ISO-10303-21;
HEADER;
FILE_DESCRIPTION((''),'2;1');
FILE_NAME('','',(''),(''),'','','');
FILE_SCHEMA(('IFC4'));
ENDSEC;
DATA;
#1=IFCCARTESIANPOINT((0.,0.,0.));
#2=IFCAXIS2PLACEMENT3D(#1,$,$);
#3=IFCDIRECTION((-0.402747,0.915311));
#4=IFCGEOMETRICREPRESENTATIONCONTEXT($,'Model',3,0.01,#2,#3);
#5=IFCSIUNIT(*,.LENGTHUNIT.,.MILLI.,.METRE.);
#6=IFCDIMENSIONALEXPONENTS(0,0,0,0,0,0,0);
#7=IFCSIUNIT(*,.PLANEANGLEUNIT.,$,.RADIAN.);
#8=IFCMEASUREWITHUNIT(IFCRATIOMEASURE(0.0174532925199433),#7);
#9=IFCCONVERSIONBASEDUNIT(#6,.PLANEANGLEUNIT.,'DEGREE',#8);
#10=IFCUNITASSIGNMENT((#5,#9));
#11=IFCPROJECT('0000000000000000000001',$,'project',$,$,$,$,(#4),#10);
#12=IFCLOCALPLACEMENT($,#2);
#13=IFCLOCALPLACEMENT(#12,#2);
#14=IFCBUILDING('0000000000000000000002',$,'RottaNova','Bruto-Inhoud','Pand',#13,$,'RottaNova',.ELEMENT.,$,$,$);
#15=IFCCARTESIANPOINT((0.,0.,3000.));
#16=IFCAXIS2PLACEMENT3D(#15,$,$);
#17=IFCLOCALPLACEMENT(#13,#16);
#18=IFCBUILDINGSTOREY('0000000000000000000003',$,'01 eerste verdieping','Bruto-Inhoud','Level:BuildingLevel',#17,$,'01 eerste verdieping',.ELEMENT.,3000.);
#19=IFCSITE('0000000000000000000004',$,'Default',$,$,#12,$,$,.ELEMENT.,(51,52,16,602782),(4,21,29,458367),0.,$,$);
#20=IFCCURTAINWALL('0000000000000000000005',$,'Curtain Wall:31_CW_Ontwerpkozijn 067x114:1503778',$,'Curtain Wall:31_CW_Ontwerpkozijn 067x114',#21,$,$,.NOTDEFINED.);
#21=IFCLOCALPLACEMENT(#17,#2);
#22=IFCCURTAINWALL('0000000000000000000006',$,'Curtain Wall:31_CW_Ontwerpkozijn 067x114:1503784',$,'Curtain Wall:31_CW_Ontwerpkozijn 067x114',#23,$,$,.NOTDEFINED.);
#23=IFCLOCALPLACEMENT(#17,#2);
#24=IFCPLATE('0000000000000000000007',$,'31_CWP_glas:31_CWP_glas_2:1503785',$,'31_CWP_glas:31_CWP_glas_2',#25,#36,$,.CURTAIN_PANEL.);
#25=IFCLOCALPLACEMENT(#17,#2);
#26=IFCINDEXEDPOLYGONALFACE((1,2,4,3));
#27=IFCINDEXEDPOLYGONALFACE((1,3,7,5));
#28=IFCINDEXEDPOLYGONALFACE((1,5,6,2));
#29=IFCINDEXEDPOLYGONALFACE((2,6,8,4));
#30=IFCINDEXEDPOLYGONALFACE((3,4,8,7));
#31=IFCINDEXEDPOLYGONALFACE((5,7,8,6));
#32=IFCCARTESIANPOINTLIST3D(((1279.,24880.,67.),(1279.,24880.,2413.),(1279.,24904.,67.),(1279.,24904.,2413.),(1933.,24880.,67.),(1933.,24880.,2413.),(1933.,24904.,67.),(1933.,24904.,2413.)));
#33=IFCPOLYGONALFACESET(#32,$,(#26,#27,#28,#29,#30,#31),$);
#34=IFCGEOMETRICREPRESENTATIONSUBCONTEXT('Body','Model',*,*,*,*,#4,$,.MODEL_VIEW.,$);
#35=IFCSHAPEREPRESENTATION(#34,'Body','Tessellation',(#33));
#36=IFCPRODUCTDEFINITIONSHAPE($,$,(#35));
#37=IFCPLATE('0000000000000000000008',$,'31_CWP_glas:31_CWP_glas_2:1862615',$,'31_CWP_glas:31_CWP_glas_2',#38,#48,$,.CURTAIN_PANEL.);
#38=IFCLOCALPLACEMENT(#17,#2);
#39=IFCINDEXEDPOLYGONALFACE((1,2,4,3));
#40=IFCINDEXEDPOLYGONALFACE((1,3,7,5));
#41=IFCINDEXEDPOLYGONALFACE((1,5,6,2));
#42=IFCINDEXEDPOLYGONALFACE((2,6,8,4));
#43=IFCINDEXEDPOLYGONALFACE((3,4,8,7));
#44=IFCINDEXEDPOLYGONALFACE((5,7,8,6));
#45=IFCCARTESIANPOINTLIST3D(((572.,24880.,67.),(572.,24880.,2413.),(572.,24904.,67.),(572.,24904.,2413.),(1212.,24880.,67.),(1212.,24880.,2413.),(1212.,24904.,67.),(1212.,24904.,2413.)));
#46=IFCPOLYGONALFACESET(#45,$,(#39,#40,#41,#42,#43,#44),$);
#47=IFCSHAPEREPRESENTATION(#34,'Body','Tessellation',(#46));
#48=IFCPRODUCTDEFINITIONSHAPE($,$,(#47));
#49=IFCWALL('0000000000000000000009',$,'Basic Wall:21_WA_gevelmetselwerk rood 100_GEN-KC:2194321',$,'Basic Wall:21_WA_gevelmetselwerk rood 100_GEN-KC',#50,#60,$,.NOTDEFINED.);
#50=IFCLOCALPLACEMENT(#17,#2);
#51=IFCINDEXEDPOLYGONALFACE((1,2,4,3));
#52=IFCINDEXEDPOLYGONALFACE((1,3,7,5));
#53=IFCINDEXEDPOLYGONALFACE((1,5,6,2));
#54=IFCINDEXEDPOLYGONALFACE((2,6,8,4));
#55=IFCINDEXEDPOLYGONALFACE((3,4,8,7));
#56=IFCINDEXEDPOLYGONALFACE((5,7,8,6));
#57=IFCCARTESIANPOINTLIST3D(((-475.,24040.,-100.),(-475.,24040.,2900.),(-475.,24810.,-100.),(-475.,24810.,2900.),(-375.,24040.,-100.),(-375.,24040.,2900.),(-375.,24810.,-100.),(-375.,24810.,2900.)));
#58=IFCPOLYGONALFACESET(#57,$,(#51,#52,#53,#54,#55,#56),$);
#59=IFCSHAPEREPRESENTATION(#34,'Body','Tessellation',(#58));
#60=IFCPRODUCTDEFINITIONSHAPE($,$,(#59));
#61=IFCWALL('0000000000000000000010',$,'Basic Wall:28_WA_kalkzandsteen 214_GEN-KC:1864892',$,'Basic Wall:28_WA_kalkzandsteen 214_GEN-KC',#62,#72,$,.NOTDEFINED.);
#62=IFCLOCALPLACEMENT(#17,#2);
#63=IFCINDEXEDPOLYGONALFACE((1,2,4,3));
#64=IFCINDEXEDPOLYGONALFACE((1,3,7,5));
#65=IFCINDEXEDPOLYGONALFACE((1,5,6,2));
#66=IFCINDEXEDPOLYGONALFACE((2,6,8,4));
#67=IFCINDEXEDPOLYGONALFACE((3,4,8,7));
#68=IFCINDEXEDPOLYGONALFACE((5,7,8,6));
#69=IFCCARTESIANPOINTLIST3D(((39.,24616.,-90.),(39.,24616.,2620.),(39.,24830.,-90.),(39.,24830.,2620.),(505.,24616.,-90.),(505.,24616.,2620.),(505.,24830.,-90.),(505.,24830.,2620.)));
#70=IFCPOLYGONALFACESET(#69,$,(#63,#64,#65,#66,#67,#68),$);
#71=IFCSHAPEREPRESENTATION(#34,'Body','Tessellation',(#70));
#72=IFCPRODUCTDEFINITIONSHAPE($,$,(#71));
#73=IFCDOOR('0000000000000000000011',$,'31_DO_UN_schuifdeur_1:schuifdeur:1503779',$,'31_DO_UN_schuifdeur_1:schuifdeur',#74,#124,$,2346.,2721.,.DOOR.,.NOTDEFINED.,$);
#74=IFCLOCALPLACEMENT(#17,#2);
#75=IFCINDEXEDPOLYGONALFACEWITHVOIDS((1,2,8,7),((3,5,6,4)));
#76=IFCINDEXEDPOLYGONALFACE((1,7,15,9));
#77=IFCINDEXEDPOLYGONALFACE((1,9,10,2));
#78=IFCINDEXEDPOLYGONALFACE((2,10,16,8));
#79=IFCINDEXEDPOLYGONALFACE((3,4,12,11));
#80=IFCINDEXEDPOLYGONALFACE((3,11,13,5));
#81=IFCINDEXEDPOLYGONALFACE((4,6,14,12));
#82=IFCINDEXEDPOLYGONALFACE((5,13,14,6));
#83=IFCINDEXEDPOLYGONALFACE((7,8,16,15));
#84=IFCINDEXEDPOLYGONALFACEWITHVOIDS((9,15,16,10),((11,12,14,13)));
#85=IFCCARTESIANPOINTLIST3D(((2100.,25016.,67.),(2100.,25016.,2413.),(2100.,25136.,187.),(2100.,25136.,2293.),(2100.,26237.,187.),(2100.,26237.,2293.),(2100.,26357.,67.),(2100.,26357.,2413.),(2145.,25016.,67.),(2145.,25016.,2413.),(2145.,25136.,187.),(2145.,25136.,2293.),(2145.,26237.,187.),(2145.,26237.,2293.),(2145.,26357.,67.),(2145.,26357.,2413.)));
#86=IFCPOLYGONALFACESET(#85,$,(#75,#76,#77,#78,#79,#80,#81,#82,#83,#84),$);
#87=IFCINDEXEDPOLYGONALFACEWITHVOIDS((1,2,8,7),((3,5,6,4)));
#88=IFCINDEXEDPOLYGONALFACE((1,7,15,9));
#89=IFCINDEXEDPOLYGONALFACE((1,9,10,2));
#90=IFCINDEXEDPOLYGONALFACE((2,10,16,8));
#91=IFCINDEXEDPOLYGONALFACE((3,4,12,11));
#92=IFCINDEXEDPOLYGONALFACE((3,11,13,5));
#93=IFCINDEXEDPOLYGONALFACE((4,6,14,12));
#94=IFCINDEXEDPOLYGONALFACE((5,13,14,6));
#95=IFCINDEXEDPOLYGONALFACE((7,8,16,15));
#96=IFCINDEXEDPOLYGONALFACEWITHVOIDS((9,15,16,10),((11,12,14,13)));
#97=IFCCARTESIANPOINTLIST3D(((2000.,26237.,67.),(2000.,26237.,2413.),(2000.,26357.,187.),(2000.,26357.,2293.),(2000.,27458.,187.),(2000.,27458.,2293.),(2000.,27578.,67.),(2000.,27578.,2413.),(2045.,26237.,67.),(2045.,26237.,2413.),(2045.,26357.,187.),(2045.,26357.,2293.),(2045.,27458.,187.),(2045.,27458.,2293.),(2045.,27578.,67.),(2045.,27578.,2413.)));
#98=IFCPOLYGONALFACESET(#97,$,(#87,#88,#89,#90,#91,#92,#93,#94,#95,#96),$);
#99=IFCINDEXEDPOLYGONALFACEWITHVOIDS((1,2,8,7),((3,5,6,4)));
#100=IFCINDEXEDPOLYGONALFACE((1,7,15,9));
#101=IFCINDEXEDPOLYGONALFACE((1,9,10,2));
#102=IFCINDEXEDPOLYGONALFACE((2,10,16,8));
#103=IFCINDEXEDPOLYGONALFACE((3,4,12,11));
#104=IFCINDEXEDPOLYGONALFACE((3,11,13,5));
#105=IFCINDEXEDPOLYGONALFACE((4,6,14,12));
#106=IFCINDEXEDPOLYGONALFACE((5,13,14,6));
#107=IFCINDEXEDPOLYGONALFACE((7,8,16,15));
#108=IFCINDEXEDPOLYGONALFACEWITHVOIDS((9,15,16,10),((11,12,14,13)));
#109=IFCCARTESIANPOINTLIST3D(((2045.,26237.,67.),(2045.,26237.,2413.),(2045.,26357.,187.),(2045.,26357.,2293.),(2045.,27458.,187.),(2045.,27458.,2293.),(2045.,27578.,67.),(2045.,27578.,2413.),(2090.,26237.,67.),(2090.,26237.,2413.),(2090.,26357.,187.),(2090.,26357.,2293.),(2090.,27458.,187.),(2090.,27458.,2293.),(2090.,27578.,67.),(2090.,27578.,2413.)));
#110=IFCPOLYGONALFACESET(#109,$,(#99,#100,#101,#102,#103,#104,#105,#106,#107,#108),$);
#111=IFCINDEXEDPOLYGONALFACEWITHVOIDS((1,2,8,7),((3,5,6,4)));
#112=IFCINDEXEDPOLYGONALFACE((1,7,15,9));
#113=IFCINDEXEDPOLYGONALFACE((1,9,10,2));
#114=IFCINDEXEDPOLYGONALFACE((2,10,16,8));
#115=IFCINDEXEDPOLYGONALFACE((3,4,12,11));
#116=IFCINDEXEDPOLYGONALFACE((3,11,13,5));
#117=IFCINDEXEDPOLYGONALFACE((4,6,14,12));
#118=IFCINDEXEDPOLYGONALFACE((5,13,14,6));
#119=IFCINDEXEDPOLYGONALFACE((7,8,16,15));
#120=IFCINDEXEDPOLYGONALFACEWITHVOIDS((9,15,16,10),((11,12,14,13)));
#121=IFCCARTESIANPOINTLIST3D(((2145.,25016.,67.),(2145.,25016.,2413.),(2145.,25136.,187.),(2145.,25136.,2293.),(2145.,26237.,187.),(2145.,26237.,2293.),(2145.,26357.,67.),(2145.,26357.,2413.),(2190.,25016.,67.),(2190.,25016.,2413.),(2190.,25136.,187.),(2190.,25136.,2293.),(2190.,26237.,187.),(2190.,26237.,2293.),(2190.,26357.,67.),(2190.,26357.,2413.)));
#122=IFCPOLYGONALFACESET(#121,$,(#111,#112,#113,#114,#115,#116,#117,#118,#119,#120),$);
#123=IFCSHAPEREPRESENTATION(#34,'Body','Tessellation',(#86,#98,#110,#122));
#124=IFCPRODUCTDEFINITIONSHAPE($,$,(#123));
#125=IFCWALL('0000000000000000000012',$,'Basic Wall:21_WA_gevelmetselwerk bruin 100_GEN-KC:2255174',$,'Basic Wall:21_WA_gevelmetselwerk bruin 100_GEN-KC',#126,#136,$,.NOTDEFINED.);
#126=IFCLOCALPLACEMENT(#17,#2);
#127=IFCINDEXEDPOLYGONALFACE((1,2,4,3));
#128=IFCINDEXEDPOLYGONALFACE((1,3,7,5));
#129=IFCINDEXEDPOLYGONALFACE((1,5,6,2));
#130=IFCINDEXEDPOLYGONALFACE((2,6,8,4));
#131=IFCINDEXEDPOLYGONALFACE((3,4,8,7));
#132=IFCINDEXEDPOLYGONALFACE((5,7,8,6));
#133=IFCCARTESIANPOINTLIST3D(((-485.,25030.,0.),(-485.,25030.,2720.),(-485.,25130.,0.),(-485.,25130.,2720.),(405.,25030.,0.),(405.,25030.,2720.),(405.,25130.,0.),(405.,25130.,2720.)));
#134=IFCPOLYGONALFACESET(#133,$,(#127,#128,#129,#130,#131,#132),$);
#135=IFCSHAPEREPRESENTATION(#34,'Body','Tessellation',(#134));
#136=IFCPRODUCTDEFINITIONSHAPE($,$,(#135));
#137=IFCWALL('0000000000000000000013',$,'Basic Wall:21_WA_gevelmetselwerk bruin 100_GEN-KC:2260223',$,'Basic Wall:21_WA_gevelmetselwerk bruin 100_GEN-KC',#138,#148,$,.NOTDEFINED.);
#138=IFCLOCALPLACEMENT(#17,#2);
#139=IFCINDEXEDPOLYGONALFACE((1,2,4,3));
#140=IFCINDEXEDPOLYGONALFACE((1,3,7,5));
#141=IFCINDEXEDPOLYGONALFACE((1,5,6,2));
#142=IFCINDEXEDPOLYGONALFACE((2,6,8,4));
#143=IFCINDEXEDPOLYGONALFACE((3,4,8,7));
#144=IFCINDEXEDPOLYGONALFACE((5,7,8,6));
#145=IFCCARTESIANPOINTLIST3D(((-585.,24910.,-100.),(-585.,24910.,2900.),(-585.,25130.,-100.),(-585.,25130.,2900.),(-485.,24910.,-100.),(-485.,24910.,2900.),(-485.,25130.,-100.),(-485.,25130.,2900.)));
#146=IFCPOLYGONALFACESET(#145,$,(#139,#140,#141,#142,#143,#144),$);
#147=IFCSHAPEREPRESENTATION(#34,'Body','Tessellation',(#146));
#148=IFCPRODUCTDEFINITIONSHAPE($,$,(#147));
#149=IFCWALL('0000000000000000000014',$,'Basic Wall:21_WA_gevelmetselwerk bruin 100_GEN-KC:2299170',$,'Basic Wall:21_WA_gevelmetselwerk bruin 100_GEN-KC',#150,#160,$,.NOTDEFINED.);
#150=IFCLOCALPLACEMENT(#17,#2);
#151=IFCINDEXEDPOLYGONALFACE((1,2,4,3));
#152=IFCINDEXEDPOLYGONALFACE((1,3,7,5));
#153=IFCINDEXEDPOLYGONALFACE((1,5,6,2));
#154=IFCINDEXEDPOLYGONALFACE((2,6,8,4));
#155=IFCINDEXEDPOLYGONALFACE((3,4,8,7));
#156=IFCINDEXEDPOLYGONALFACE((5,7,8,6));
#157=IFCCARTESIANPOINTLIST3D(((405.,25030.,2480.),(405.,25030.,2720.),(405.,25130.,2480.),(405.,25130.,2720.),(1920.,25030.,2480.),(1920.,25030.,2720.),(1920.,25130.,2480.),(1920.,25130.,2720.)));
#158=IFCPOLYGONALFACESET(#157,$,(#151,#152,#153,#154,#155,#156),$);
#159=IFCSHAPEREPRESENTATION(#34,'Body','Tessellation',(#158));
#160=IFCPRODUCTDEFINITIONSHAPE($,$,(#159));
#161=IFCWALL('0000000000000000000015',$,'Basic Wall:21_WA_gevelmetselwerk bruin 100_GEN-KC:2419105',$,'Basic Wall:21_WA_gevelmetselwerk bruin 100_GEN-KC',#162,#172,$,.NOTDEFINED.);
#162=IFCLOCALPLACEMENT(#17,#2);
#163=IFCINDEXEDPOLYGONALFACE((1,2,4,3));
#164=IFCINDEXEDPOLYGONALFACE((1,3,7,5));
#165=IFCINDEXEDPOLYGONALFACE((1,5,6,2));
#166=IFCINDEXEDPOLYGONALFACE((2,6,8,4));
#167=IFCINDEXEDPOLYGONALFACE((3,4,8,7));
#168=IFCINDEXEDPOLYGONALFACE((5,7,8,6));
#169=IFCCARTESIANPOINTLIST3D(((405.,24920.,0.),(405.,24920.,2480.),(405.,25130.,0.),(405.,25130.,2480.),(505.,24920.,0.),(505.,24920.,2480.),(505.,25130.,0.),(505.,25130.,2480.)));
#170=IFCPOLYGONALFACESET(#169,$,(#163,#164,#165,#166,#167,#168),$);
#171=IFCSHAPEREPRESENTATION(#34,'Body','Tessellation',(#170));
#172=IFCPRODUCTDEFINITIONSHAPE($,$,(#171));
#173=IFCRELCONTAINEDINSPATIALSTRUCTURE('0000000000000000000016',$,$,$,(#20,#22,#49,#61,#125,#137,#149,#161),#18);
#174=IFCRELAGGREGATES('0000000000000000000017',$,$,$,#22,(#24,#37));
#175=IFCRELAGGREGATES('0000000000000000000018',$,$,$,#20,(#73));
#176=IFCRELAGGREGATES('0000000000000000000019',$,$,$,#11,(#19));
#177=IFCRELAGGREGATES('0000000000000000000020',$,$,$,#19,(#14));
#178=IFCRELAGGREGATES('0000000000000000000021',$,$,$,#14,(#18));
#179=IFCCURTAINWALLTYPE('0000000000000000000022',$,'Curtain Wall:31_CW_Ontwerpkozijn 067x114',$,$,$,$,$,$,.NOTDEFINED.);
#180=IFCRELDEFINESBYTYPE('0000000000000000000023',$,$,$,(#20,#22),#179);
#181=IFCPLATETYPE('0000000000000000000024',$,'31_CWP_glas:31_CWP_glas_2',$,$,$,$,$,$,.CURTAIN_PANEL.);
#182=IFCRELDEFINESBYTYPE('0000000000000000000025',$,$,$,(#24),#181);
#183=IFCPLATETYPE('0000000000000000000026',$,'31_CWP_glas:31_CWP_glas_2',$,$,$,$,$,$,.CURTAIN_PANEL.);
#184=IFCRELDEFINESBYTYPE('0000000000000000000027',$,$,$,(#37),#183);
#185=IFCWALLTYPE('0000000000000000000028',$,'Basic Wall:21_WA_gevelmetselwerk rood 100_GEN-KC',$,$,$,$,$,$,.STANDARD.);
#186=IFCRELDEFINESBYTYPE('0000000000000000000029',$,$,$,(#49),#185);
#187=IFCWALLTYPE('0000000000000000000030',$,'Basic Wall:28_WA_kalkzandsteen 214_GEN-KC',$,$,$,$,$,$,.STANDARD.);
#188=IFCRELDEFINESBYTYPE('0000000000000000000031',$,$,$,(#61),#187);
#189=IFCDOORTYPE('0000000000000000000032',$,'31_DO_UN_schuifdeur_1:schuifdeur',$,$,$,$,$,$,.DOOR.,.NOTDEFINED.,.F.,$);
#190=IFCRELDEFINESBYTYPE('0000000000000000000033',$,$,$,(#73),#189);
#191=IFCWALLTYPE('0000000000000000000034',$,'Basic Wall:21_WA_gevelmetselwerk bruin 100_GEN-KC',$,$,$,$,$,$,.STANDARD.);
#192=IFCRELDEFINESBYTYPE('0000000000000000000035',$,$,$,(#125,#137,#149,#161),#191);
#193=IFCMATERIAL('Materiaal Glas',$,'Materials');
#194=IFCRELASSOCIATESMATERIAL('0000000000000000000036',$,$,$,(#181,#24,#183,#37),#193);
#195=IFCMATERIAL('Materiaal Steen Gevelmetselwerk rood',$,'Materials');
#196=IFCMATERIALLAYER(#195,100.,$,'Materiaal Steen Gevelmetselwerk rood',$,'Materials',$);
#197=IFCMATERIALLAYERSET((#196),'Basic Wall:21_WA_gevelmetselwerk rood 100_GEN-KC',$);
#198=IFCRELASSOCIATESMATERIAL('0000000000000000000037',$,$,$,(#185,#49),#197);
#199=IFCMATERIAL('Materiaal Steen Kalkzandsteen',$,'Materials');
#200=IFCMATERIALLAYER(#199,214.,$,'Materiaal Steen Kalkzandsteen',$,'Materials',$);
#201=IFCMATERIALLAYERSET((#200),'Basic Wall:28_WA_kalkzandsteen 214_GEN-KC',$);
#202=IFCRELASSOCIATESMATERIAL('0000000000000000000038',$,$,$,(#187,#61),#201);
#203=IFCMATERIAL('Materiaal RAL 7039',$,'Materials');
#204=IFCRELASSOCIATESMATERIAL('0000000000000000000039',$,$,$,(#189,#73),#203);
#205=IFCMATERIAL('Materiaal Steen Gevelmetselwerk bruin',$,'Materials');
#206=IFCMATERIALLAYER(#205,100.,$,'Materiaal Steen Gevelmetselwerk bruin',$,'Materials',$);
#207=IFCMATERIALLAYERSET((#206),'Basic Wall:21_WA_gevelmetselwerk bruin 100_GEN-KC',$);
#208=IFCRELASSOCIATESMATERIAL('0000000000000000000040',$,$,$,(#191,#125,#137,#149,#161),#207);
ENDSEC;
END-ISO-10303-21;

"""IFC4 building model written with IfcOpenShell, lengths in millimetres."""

from ifc_helpers import new_model, entity, si_unit, converted_unit, direction, frame, frame_2d, origin, place, context, subcontext, project, spatial, polyline, rectangle, outline, extrude, source, transform, mapped, material, layer, layer_set, type_object, type_shapes, element, aggregate, save


model = new_model("IFC4")

# Units and contexts
model_context = context("Model", 3, precision=0.01, world=origin(), true_north=direction((-0.402747, 0.915311)))
body_context = subcontext(model_context, "Body", "Model", "MODEL_VIEW")
ifc_project = project(units=[si_unit("LENGTHUNIT", "METRE", prefix="MILLI"), converted_unit("PLANEANGLEUNIT", "DEGREE", entity("IfcRatioMeasure", 0.0174532925199433), si_unit("PLANEANGLEUNIT", "RADIAN"), dimensions=[0, 0, 0, 0, 0, 0, 0])], contexts=[model_context])

# Site, building, storey
site_placement = place(None, origin())
site = spatial("IfcSite", under=ifc_project, at=site_placement, Name="Default", CompositionType="ELEMENT", RefLatitude=(51, 52, 16, 602782), RefLongitude=(4, 21, 29, 458367), RefElevation=0.0)
building_placement = place(site_placement, origin())
building = spatial("IfcBuilding", under=site, at=building_placement, Name="RottaNova", Description="Bruto-Inhoud", ObjectType="Pand", LongName="RottaNova", CompositionType="ELEMENT")
storey_placement = place(building_placement, frame((0.0, 0.0, 3000.0)))
storey = spatial("IfcBuildingStorey", under=building, at=storey_placement, Name="01 eerste verdieping", Description="Bruto-Inhoud", ObjectType="Level:BuildingLevel", LongName="01 eerste verdieping", CompositionType="ELEMENT", Elevation=3000.0)

# Curtain walls
curtain_wall_type = type_object("IfcCurtainWallType", Name="Curtain Wall:31_CW_Ontwerpkozijn 067x114", PredefinedType="NOTDEFINED")
curtain_wall_1_placement = place(storey_placement, frame((0.0, 0.0, -3000.0)))
curtain_wall_1 = element("IfcCurtainWall", 1, at=curtain_wall_1_placement, inside=storey, type_object=curtain_wall_type, Name="Curtain Wall:31_CW_Ontwerpkozijn 067x114:1503778", ObjectType="Curtain Wall:31_CW_Ontwerpkozijn 067x114", PredefinedType="NOTDEFINED")
ifc_material_1 = material(Name="Materiaal RAL 7039", Category="Materials")
curtain_wall_2_placement = place(storey_placement, frame((0.0, 0.0, -3000.0)))
curtain_wall_2 = element("IfcCurtainWall", 2, at=curtain_wall_2_placement, inside=storey, type_object=curtain_wall_type, Name="Curtain Wall:31_CW_Ontwerpkozijn 067x114:1503784", ObjectType="Curtain Wall:31_CW_Ontwerpkozijn 067x114", PredefinedType="NOTDEFINED")

# Plates
ifc_material_2 = material(Name="Materiaal Glas", Category="Materials")
plate_type_1 = type_object("IfcPlateType", Name="31_CWP_glas:31_CWP_glas_2", PredefinedType="CURTAIN_PANEL", material=ifc_material_2)
shared_shape_1 = source(origin(), body_context, "Body", "SweptSolid", [
    extrude(rectangle(XDim=24.0, YDim=654.0, at=frame_2d((0.0, 0.0), x_axis=(1.0, 0.0))), frame((327.0, 12.0, 0.0), z_axis=(0.0, 0.0, 1.0), x_axis=(0.0, 1.0, 0.0)), (0.0, 0.0, 1.0), 2346.0),
])
type_shapes(plate_type_1, [shared_shape_1])
plate_1_placement = place(curtain_wall_2_placement, frame((1933.0, 24904.0, 3067.0), z_axis=(0.0, 0.0, 1.0), x_axis=(-1.0, 0.0, 0.0)))
plate_1 = element("IfcPlate", 3, at=plate_1_placement, type_object=plate_type_1, material=ifc_material_2, Name="31_CWP_glas:31_CWP_glas_2:1503785", ObjectType="31_CWP_glas:31_CWP_glas_2", PredefinedType="CURTAIN_PANEL", context=body_context, shape_type="MappedRepresentation", body=[
    mapped(shared_shape_1, transform((0.0, 0.0, 0.0), scale=1.0)),
])
plate_type_2 = type_object("IfcPlateType", Name="31_CWP_glas:31_CWP_glas_2", PredefinedType="CURTAIN_PANEL", material=ifc_material_2)
shared_shape_2 = source(origin(), body_context, "Body", "SweptSolid", [
    extrude(rectangle(XDim=24.0, YDim=640.0, at=frame_2d((0.0, 0.0), x_axis=(1.0, 0.0))), frame((320.0, 12.0, 0.0), z_axis=(0.0, 0.0, 1.0), x_axis=(0.0, 1.0, 0.0)), (0.0, 0.0, 1.0), 2346.0),
])
type_shapes(plate_type_2, [shared_shape_2])
plate_2_placement = place(curtain_wall_2_placement, frame((1212.0, 24904.0, 3067.0), z_axis=(0.0, 0.0, 1.0), x_axis=(-1.0, 0.0, 0.0)))
plate_2 = element("IfcPlate", 4, at=plate_2_placement, type_object=plate_type_2, material=ifc_material_2, Name="31_CWP_glas:31_CWP_glas_2:1862615", ObjectType="31_CWP_glas:31_CWP_glas_2", PredefinedType="CURTAIN_PANEL", context=body_context, shape_type="MappedRepresentation", body=[
    mapped(shared_shape_2, transform((0.0, 0.0, 0.0), scale=1.0)),
])
aggregate(curtain_wall_2, [plate_1, plate_2])

# Walls
ifc_material_3 = material(Name="Materiaal Steen Gevelmetselwerk rood", Category="Materials")
ifc_layer_1 = layer(ifc_material_3, 100.0, Name="Materiaal Steen Gevelmetselwerk rood", Category="Materials")
ifc_layer_set_1 = layer_set([ifc_layer_1], Name="Basic Wall:21_WA_gevelmetselwerk rood 100_GEN-KC")
wall_type_1 = type_object("IfcWallType", Name="Basic Wall:21_WA_gevelmetselwerk rood 100_GEN-KC", PredefinedType="STANDARD", material=ifc_layer_set_1)
wall_1_placement = place(storey_placement, frame((-425.0, 24810.0, -100.0), z_axis=(0.0, 0.0, 1.0), x_axis=(0.0, -1.0, 0.0)))
element("IfcWall", 5, at=wall_1_placement, inside=storey, type_object=wall_type_1, material=ifc_layer_set_1, Name="Basic Wall:21_WA_gevelmetselwerk rood 100_GEN-KC:2194321", ObjectType="Basic Wall:21_WA_gevelmetselwerk rood 100_GEN-KC", PredefinedType="NOTDEFINED", context=body_context, shape_type="SweptSolid", body=[
    extrude(rectangle(XDim=770.0, YDim=100.0, at=frame_2d((385.0, 0.0), x_axis=(-1.0, 0.0))), origin(), (0.0, 0.0, 1.0), 3000.0),
])
ifc_material_4 = material(Name="Materiaal Steen Kalkzandsteen", Category="Materials")
ifc_layer_2 = layer(ifc_material_4, 214.0, Name="Materiaal Steen Kalkzandsteen", Category="Materials")
ifc_layer_set_2 = layer_set([ifc_layer_2], Name="Basic Wall:28_WA_kalkzandsteen 214_GEN-KC")
wall_type_2 = type_object("IfcWallType", Name="Basic Wall:28_WA_kalkzandsteen 214_GEN-KC", PredefinedType="STANDARD", material=ifc_layer_set_2)
wall_2_placement = place(storey_placement, frame((39.0, 24723.0, -90.0)))
element("IfcWall", 6, at=wall_2_placement, inside=storey, type_object=wall_type_2, material=ifc_layer_set_2, Name="Basic Wall:28_WA_kalkzandsteen 214_GEN-KC:1864892", ObjectType="Basic Wall:28_WA_kalkzandsteen 214_GEN-KC", PredefinedType="NOTDEFINED", context=body_context, shape_type="SweptSolid", body=[
    extrude(rectangle(XDim=466.0, YDim=214.0, at=frame_2d((233.0, 0.0), x_axis=(-1.0, 0.0))), origin(), (0.0, 0.0, 1.0), 2710.0),
])

# Door
door_type = type_object("IfcDoorType", Name="31_DO_UN_schuifdeur_1:schuifdeur", OperationType="NOTDEFINED", ParameterTakesPrecedence=False, PredefinedType="DOOR", material=ifc_material_1)
shared_shape_3 = source(origin(), body_context, "Body", "SweptSolid", [
    extrude(outline(polyline([(-670.5, -1173.0), (670.5, -1173.0), (670.5, 1173.0), (-670.5, 1173.0), (-670.5, -1173.0)]), holes=[polyline([(-550.5, -1053.0), (-550.5, 1053.0), (550.5, 1053.0), (550.5, -1053.0), (-550.5, -1053.0)])]), frame((-610.5, 90.0, 1173.0), z_axis=(0.0, -1.0, 0.0), x_axis=(-1.0, 0.0, 0.0)), (0.0, 0.0, 1.0), 45.0),
    extrude(outline(polyline([(-670.5, -1173.0), (670.5, -1173.0), (670.5, 1173.0), (-670.5, 1173.0), (-670.5, -1173.0)]), holes=[polyline([(-550.5, -1053.0), (-550.5, 1053.0), (550.5, 1053.0), (550.5, -1053.0), (-550.5, -1053.0)])]), frame((610.5, 190.0, 1173.0), z_axis=(0.0, -1.0, 0.0), x_axis=(-1.0, 0.0, 0.0)), (0.0, 0.0, 1.0), 45.0),
    extrude(outline(polyline([(-670.5, -1173.0), (670.5, -1173.0), (670.5, 1173.0), (-670.5, 1173.0), (-670.5, -1173.0)]), holes=[polyline([(-550.5, -1053.0), (-550.5, 1053.0), (550.5, 1053.0), (550.5, -1053.0), (-550.5, -1053.0)])]), frame((610.5, 145.0, 1173.0), z_axis=(0.0, -1.0, 0.0), x_axis=(-1.0, 0.0, 0.0)), (0.0, 0.0, 1.0), 45.0),
    extrude(outline(polyline([(-670.5, -1173.0), (670.5, -1173.0), (670.5, 1173.0), (-670.5, 1173.0), (-670.5, -1173.0)]), holes=[polyline([(-550.5, -1053.0), (-550.5, 1053.0), (550.5, 1053.0), (550.5, -1053.0), (-550.5, -1053.0)])]), frame((-610.5, 45.0, 1173.0), z_axis=(0.0, -1.0, 0.0), x_axis=(-1.0, 0.0, 0.0)), (0.0, 0.0, 1.0), 45.0),
])
type_shapes(door_type, [shared_shape_3])
door_placement = place(curtain_wall_1_placement, frame((2190.0, 26297.0, 3067.0), z_axis=(0.0, 0.0, 1.0), x_axis=(0.0, 1.0, 0.0)))
door = element("IfcDoor", 7, at=door_placement, type_object=door_type, material=ifc_material_1, Name="31_DO_UN_schuifdeur_1:schuifdeur:1503779", ObjectType="31_DO_UN_schuifdeur_1:schuifdeur", OperationType="NOTDEFINED", OverallHeight=2346.0, OverallWidth=2721.0, PredefinedType="DOOR", context=body_context, shape_type="MappedRepresentation", body=[
    mapped(shared_shape_3, transform((0.0, 0.0, 0.0), scale=1.0)),
])
aggregate(curtain_wall_1, [door])

# Shared definitions
ifc_material_5 = material(Name="Materiaal Steen Gevelmetselwerk bruin", Category="Materials")
ifc_layer_3 = layer(ifc_material_5, 100.0, Name="Materiaal Steen Gevelmetselwerk bruin", Category="Materials")
ifc_layer_set_3 = layer_set([ifc_layer_3], Name="Basic Wall:21_WA_gevelmetselwerk bruin 100_GEN-KC")
wall_type_3 = type_object("IfcWallType", Name="Basic Wall:21_WA_gevelmetselwerk bruin 100_GEN-KC", PredefinedType="STANDARD", material=ifc_layer_set_3)

# Walls
wall_3_placement = place(storey_placement, frame((-485.0, 25080.0, 0.0)))
element("IfcWall", 8, at=wall_3_placement, inside=storey, type_object=wall_type_3, material=ifc_layer_set_3, Name="Basic Wall:21_WA_gevelmetselwerk bruin 100_GEN-KC:2255174", ObjectType="Basic Wall:21_WA_gevelmetselwerk bruin 100_GEN-KC", PredefinedType="NOTDEFINED", context=body_context, shape_type="SweptSolid", body=[
    extrude(rectangle(XDim=890.0, YDim=100.0, at=frame_2d((445.0, 0.0), x_axis=(-1.0, 0.0))), origin(), (0.0, 0.0, 1.0), 2720.0),
])
wall_4_placement = place(storey_placement, frame((-535.0, 25130.0, -100.0), z_axis=(0.0, 0.0, 1.0), x_axis=(0.0, -1.0, 0.0)))
element("IfcWall", 9, at=wall_4_placement, inside=storey, type_object=wall_type_3, material=ifc_layer_set_3, Name="Basic Wall:21_WA_gevelmetselwerk bruin 100_GEN-KC:2260223", ObjectType="Basic Wall:21_WA_gevelmetselwerk bruin 100_GEN-KC", PredefinedType="NOTDEFINED", context=body_context, shape_type="SweptSolid", body=[
    extrude(rectangle(XDim=220.0, YDim=100.0, at=frame_2d((110.0, 0.0), x_axis=(-1.0, 0.0))), origin(), (0.0, 0.0, 1.0), 3000.0),
])
wall_5_placement = place(storey_placement, frame((405.0, 25080.0, 2480.0)))
element("IfcWall", 10, at=wall_5_placement, inside=storey, type_object=wall_type_3, material=ifc_layer_set_3, Name="Basic Wall:21_WA_gevelmetselwerk bruin 100_GEN-KC:2299170", ObjectType="Basic Wall:21_WA_gevelmetselwerk bruin 100_GEN-KC", PredefinedType="NOTDEFINED", context=body_context, shape_type="SweptSolid", body=[
    extrude(rectangle(XDim=1515.0, YDim=100.0, at=frame_2d((757.5, 0.0), x_axis=(-1.0, 0.0))), origin(), (0.0, 0.0, 1.0), 240.0),
])
wall_6_placement = place(storey_placement, frame((455.0, 24920.0, 0.0), z_axis=(0.0, 0.0, 1.0), x_axis=(0.0, 1.0, 0.0)))
element("IfcWall", 11, at=wall_6_placement, inside=storey, type_object=wall_type_3, material=ifc_layer_set_3, Name="Basic Wall:21_WA_gevelmetselwerk bruin 100_GEN-KC:2419105", ObjectType="Basic Wall:21_WA_gevelmetselwerk bruin 100_GEN-KC", PredefinedType="NOTDEFINED", context=body_context, shape_type="SweptSolid", body=[
    extrude(rectangle(XDim=210.0, YDim=100.0, at=frame_2d((105.0, 0.0), x_axis=(-1.0, 0.0))), origin(), (0.0, 0.0, 1.0), 2480.0),
])

save(model, "model.ifc")
